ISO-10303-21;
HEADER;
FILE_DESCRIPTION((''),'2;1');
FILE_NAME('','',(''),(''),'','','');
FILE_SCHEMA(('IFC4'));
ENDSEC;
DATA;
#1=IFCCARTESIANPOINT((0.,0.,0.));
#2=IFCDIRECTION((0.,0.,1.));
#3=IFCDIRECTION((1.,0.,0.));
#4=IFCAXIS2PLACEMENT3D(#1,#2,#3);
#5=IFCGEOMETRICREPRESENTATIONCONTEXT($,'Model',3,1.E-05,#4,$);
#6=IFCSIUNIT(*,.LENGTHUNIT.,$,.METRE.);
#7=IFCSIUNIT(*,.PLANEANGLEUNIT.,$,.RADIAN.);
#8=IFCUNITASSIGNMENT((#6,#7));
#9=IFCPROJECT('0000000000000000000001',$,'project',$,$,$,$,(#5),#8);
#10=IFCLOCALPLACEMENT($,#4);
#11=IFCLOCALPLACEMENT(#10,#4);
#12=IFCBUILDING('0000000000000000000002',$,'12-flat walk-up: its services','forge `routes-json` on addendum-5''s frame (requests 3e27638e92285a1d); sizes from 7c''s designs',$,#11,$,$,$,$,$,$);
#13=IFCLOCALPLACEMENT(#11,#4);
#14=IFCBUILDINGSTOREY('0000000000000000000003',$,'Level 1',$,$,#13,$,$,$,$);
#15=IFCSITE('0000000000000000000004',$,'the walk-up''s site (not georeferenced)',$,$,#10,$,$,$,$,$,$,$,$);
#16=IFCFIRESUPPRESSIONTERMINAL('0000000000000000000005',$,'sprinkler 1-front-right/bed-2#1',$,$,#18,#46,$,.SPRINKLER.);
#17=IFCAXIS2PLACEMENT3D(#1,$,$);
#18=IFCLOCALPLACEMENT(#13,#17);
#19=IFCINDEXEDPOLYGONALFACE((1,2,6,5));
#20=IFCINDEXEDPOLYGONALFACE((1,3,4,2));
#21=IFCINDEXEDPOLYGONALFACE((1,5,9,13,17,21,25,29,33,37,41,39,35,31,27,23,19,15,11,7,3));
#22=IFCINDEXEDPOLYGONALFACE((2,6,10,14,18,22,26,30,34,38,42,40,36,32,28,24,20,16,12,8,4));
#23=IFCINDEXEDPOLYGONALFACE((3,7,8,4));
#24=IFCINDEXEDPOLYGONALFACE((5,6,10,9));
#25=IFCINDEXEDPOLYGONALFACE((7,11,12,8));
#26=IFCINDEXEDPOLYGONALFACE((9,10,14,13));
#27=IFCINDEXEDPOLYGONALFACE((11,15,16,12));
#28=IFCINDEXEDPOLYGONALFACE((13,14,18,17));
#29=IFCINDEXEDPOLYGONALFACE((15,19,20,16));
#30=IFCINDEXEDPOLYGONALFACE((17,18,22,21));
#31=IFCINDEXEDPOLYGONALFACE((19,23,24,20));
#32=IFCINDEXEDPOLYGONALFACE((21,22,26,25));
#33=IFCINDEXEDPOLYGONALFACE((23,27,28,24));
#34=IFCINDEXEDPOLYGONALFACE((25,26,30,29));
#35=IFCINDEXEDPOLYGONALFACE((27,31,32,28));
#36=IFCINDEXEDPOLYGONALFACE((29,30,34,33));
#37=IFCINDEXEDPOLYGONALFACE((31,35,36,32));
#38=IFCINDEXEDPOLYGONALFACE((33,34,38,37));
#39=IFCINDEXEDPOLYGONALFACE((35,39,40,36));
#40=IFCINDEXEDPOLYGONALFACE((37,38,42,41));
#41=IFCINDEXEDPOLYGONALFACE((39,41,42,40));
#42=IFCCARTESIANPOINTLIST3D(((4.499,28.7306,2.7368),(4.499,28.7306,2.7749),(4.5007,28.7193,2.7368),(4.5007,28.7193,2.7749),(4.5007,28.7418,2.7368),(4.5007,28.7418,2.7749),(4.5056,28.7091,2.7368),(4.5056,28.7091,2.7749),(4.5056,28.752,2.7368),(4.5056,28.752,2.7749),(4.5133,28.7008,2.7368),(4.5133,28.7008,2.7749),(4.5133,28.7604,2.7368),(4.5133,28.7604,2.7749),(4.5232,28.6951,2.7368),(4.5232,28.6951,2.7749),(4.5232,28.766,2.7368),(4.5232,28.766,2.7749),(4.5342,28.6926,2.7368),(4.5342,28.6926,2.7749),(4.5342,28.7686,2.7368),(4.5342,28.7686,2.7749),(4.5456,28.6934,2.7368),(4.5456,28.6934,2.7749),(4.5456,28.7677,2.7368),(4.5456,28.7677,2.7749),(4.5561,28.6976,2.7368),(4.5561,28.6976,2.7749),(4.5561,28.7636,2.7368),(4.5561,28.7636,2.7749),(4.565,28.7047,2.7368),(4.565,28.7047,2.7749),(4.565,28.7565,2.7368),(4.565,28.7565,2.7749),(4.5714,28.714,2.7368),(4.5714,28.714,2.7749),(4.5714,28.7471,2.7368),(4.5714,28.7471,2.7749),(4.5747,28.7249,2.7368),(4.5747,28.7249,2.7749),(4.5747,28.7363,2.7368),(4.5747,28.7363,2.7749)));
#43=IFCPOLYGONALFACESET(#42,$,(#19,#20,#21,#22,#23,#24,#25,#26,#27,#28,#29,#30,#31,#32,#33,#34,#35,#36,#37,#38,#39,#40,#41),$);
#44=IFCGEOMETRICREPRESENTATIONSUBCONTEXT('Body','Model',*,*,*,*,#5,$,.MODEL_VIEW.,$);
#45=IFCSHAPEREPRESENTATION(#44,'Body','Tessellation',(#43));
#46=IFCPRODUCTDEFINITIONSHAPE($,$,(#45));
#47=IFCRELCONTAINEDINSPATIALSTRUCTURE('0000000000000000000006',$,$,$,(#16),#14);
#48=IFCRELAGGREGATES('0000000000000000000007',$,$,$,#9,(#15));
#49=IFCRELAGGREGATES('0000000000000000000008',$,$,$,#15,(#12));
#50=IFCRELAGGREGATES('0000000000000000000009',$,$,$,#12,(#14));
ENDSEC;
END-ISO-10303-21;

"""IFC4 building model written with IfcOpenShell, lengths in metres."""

from ifc_helpers import new_model, entity, si_unit, frame, origin_with_axes, place, context, subcontext, project, spatial, element, save


model = new_model("IFC4")

# Units and contexts
model_context = context("Model", 3, precision=1e-05, world=origin_with_axes())
body_context = subcontext(model_context, "Body", "Model", "MODEL_VIEW")
ifc_project = project(units=[si_unit("LENGTHUNIT", "METRE"), si_unit("PLANEANGLEUNIT", "RADIAN")], contexts=[model_context])

# Site, building, storey
site_placement = place(None, origin_with_axes())
site = spatial("IfcSite", under=ifc_project, at=site_placement, Name="the walk-up's site (not georeferenced)")
building_placement = place(site_placement, origin_with_axes())
building = spatial("IfcBuilding", under=site, at=building_placement, Name="12-flat walk-up: its services", Description="forge `routes-json` on addendum-5's frame (requests 3e27638e92285a1d); sizes from 7c's designs")
storey_placement = place(building_placement, origin_with_axes())
storey = spatial("IfcBuildingStorey", under=building, at=storey_placement, Name="Level 1")

# Fire suppression terminal
fire_suppression_terminal_placement = place(storey_placement, frame((4.5371, 28.7306, 2.7749), z_axis=(0.0, 0.0, 1.0), x_axis=(1.0, 0.0, 0.0)))
element("IfcFireSuppressionTerminal", 1, at=fire_suppression_terminal_placement, inside=storey, Name="sprinkler 1-front-right/bed-2#1", PredefinedType="SPRINKLER", context=body_context, shape_type="AdvancedSweptSolid", body=[
    entity("IfcSweptDiskSolid", entity("IfcPolyline", [entity("IfcCartesianPoint", [0.0, 0.0, 0.0]), entity("IfcCartesianPoint", [0.0, 0.0, -0.0381])]), 0.0381),
])

save(model, "model.ifc")
